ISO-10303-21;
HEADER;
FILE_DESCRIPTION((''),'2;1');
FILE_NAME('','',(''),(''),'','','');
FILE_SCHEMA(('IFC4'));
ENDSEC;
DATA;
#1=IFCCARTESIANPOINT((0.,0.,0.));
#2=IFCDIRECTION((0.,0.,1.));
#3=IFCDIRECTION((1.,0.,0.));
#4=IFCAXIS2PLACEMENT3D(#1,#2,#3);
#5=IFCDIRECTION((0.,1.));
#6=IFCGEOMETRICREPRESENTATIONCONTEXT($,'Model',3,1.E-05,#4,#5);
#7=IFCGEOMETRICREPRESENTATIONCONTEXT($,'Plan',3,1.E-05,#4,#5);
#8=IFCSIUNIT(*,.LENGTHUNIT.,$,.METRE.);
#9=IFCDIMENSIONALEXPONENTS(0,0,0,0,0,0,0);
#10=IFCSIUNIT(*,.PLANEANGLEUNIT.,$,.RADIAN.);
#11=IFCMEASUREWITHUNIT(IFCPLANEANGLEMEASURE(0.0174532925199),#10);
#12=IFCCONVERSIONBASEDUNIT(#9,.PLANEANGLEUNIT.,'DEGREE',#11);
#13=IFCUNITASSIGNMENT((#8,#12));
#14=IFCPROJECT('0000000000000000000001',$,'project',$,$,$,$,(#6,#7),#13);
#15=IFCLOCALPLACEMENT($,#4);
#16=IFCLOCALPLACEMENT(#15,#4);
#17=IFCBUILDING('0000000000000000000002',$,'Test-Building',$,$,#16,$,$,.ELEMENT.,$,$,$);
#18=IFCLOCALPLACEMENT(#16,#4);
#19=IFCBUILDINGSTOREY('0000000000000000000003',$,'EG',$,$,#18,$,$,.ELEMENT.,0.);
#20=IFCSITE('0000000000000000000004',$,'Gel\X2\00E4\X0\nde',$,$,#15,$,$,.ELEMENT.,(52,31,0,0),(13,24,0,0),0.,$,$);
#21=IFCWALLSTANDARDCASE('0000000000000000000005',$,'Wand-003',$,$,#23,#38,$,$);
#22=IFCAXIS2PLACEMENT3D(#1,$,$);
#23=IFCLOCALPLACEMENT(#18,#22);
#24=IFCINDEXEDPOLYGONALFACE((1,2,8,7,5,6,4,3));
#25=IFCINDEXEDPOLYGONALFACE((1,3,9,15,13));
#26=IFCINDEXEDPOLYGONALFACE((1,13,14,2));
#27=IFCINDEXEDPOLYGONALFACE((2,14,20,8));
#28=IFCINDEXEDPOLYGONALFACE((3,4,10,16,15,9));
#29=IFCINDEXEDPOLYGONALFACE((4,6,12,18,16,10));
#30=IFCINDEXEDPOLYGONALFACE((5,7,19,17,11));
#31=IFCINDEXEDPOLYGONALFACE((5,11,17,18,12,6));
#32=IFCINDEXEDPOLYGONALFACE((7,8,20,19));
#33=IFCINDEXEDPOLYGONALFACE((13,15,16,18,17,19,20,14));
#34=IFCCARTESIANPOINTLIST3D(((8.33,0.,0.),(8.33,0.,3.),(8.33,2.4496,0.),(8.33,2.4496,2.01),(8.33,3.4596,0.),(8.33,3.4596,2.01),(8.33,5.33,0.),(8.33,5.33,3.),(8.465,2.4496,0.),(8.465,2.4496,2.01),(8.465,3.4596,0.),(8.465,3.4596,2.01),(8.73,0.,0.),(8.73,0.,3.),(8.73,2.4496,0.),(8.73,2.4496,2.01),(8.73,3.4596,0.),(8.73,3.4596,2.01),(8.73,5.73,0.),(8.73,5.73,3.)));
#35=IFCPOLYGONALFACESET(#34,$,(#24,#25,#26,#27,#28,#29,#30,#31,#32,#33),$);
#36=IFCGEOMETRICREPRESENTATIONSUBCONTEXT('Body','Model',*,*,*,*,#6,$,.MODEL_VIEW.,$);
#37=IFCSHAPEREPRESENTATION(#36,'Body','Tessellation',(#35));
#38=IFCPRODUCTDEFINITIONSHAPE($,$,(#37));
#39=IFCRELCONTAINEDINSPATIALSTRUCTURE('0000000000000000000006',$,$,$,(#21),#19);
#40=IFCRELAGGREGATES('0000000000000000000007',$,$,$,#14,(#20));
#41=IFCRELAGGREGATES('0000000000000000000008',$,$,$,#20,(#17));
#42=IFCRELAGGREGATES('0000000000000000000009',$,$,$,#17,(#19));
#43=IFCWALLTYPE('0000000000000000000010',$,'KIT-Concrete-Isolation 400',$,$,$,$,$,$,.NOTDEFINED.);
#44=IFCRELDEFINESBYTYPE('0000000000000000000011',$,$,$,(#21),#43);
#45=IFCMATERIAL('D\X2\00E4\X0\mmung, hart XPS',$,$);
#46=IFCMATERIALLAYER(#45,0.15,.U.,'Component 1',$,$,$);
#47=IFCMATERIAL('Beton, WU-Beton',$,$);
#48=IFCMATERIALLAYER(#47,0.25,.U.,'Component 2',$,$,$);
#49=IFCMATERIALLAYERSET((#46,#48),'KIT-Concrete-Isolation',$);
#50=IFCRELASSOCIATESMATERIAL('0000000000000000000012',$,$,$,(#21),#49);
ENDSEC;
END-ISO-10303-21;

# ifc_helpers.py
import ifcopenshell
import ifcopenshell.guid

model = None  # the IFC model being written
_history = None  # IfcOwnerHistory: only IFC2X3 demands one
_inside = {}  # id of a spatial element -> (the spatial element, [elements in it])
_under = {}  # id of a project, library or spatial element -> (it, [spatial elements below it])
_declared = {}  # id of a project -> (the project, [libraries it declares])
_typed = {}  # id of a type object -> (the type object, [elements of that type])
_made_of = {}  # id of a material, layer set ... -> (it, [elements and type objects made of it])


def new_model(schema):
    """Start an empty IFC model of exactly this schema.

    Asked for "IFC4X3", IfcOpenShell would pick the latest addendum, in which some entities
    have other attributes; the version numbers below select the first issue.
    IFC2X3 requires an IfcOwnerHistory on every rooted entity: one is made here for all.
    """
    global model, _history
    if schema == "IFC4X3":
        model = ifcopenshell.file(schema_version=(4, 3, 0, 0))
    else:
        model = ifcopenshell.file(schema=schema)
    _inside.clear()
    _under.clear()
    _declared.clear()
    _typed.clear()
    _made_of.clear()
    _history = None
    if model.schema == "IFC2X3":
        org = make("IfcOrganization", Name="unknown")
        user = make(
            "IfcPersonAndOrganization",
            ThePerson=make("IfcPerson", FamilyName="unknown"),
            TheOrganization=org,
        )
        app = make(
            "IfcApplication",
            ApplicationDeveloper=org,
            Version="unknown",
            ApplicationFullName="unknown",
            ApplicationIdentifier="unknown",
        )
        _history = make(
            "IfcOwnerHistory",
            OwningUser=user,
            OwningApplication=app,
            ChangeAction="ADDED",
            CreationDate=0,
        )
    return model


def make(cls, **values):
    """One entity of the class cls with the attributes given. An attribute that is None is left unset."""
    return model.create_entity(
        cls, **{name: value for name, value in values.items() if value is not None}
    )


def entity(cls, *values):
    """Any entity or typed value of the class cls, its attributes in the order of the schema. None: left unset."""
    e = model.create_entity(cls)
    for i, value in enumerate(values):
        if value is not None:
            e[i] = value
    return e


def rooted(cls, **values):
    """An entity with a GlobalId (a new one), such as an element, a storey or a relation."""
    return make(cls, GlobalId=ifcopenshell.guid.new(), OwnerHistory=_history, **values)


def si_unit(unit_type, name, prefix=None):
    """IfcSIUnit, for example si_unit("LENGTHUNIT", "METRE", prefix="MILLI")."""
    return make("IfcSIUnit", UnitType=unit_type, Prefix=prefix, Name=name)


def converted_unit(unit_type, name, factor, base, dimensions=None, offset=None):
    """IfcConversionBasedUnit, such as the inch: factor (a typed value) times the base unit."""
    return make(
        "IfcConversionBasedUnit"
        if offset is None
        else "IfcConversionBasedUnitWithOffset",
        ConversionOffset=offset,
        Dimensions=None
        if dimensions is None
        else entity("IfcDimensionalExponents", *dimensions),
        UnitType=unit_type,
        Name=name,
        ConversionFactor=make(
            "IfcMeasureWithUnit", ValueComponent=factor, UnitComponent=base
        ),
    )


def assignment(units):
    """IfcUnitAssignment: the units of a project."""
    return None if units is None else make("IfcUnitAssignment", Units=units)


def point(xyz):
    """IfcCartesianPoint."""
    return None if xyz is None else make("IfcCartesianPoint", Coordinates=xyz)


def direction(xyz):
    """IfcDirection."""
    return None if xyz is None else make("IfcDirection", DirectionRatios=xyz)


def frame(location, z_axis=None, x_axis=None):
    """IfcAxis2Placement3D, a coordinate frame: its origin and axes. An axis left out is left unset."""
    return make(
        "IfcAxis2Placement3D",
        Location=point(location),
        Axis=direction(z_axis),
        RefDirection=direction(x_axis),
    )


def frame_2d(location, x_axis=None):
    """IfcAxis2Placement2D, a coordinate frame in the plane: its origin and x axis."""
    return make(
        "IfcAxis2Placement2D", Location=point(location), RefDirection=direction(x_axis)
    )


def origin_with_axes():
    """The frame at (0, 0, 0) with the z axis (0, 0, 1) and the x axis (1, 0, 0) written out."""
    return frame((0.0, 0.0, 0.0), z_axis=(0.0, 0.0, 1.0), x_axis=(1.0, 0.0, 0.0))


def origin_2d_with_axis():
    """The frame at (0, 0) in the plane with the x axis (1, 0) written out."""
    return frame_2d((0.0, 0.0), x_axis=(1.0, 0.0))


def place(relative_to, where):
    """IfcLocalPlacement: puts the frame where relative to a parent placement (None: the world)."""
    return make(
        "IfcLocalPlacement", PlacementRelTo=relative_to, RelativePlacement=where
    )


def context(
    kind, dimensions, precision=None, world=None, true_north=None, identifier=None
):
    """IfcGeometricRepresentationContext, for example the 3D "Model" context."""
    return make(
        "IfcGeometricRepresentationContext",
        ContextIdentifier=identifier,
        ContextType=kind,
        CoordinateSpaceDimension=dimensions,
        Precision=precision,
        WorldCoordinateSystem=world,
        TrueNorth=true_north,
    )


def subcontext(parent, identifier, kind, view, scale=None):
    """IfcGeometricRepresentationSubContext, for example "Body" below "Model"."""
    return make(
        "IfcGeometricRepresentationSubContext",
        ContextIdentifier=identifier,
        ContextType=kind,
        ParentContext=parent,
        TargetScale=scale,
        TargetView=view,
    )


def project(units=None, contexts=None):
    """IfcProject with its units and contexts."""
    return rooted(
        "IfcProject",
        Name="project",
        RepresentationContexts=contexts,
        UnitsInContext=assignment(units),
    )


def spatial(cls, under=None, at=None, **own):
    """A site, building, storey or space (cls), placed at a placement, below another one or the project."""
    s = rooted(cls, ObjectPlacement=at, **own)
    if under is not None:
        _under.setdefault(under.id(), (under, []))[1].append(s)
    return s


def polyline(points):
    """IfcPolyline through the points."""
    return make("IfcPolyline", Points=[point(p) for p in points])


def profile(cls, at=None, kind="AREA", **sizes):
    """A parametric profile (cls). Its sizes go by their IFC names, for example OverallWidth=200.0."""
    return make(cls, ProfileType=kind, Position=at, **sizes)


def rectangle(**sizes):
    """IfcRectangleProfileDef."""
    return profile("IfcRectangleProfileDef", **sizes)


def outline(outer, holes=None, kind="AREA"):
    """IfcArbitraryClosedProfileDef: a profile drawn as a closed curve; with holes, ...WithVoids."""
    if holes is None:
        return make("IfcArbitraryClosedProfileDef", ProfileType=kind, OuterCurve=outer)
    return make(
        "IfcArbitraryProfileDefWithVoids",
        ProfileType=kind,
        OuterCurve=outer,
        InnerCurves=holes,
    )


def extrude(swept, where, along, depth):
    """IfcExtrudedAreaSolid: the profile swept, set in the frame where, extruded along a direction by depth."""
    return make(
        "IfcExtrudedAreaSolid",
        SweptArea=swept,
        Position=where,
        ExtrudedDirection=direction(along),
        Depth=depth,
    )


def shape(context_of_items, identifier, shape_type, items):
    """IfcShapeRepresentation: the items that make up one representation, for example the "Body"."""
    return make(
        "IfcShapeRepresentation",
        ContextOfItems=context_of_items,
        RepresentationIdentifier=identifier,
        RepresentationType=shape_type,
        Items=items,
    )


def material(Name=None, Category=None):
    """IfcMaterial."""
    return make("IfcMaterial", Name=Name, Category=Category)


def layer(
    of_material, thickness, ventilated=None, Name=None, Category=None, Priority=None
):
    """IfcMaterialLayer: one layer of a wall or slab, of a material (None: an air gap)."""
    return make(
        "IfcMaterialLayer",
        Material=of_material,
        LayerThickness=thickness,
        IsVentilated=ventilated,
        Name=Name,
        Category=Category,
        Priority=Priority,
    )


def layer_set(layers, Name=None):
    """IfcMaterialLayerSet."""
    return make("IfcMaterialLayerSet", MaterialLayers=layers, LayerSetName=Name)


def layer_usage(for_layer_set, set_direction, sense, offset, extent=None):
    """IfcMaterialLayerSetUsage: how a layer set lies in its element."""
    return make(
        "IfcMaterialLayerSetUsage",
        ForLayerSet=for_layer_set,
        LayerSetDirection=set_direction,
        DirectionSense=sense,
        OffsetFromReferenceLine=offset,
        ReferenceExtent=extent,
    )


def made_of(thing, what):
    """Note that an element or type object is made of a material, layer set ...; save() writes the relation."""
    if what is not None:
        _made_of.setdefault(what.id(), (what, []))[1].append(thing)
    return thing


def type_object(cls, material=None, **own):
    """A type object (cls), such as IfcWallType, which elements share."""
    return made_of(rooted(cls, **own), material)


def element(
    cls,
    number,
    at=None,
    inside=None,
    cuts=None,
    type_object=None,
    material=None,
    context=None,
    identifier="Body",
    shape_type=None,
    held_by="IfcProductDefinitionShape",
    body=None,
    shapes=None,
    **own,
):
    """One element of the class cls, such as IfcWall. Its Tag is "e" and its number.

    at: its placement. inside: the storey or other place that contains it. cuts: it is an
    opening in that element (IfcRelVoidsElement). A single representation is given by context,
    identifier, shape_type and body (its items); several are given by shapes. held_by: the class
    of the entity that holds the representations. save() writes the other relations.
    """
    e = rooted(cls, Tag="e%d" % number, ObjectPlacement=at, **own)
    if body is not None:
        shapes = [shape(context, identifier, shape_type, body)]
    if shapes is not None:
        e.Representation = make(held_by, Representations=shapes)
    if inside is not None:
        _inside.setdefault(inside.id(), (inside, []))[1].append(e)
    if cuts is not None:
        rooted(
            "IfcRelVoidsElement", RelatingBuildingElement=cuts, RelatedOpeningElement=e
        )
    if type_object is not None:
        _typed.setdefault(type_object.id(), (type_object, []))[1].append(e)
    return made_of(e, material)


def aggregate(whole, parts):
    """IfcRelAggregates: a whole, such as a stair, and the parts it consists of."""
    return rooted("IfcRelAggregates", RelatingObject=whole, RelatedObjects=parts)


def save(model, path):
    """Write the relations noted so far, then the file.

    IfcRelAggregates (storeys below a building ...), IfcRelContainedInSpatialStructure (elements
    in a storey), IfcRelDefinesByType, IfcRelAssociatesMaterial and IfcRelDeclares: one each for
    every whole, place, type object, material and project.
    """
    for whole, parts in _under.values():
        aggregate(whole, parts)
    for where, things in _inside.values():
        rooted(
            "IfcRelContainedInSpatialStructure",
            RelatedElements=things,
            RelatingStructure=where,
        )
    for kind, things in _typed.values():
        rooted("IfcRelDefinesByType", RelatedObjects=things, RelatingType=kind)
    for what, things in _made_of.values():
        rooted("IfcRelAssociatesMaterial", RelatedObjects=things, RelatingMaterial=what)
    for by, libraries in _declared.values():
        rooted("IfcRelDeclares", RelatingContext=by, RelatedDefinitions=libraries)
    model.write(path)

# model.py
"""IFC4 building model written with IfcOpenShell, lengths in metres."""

from ifc_helpers import new_model, entity, si_unit, converted_unit, direction, frame, origin_with_axes, origin_2d_with_axis, place, context, subcontext, project, spatial, polyline, rectangle, outline, extrude, material, layer, layer_set, layer_usage, type_object, element, save


model = new_model("IFC4")

# Units and contexts
model_context = context("Model", 3, precision=1e-05, world=origin_with_axes(), true_north=direction((0.0, 1.0)))
plan_context = context("Plan", 3, precision=1e-05, world=origin_with_axes(), true_north=direction((0.0, 1.0)))
body_context = subcontext(model_context, "Body", "Model", "MODEL_VIEW")
ifc_project = project(units=[si_unit("LENGTHUNIT", "METRE"), converted_unit("PLANEANGLEUNIT", "DEGREE", entity("IfcPlaneAngleMeasure", 0.0174532925199), si_unit("PLANEANGLEUNIT", "RADIAN"), dimensions=[0, 0, 0, 0, 0, 0, 0])], contexts=[model_context, plan_context])

# Site, building, storey
site_placement = place(None, origin_with_axes())
site = spatial("IfcSite", under=ifc_project, at=site_placement, Name="Gelände", CompositionType="ELEMENT", RefLatitude=(52, 31, 0, 0), RefLongitude=(13, 24, 0, 0), RefElevation=0.0)
building_placement = place(site_placement, origin_with_axes())
building = spatial("IfcBuilding", under=site, at=building_placement, Name="Test-Building", CompositionType="ELEMENT")
storey_placement = place(building_placement, origin_with_axes())
storey = spatial("IfcBuildingStorey", under=building, at=storey_placement, Name="EG", CompositionType="ELEMENT", Elevation=0.0)

# Wall, opening
ifc_material_1 = material(Name="Dämmung, hart XPS")
ifc_layer_1 = layer(ifc_material_1, 0.15, ventilated="UNKNOWN", Name="Component 1")
ifc_material_2 = material(Name="Beton, WU-Beton")
ifc_layer_2 = layer(ifc_material_2, 0.25, ventilated="UNKNOWN", Name="Component 2")
ifc_layer_set = layer_set([ifc_layer_1, ifc_layer_2], Name="KIT-Concrete-Isolation")
ifc_layer_usage = layer_usage(ifc_layer_set, "AXIS2", "NEGATIVE", 0.0)
wall_type = type_object("IfcWallType", Name="KIT-Concrete-Isolation 400", PredefinedType="NOTDEFINED")
wall_placement = place(storey_placement, frame((8.73, 5.73, 0.0), z_axis=(0.0, 0.0, 1.0), x_axis=(0.0, -1.0, 0.0)))
wall = element("IfcWallStandardCase", 1, at=wall_placement, inside=storey, type_object=wall_type, material=ifc_layer_usage, Name="Wand-003", context=body_context, shape_type="SweptSolid", body=[
    extrude(outline(polyline([(0.4, -0.4), (5.73, -0.4), (5.73, 0.0), (0.0, 0.0), (0.4, -0.4)])), origin_with_axes(), (0.0, 0.0, 1.0), 3.0),
])
opening_placement = place(wall_placement, frame((2.7754, 0.0, 0.0), z_axis=(0.0, 0.0, 1.0), x_axis=(1.0, 0.0, 0.0)))
element("IfcOpeningElement", 2, at=opening_placement, cuts=wall, context=body_context, shape_type="SweptSolid", body=[
    extrude(rectangle(XDim=1.01, YDim=2.01, at=origin_2d_with_axis()), frame((0.0, -0.265, 1.005), z_axis=(0.0, -1.0, 0.0), x_axis=(-1.0, 0.0, 0.0)), (0.0, 0.0, -1.0), 0.665),
    extrude(rectangle(XDim=1.01, YDim=2.01, at=origin_2d_with_axis()), frame((0.0, -0.265, 1.005), z_axis=(0.0, 1.0, 0.0), x_axis=(-1.0, 0.0, 0.0)), (0.0, 0.0, -1.0), 0.535),
])

save(model, "model.ifc")
